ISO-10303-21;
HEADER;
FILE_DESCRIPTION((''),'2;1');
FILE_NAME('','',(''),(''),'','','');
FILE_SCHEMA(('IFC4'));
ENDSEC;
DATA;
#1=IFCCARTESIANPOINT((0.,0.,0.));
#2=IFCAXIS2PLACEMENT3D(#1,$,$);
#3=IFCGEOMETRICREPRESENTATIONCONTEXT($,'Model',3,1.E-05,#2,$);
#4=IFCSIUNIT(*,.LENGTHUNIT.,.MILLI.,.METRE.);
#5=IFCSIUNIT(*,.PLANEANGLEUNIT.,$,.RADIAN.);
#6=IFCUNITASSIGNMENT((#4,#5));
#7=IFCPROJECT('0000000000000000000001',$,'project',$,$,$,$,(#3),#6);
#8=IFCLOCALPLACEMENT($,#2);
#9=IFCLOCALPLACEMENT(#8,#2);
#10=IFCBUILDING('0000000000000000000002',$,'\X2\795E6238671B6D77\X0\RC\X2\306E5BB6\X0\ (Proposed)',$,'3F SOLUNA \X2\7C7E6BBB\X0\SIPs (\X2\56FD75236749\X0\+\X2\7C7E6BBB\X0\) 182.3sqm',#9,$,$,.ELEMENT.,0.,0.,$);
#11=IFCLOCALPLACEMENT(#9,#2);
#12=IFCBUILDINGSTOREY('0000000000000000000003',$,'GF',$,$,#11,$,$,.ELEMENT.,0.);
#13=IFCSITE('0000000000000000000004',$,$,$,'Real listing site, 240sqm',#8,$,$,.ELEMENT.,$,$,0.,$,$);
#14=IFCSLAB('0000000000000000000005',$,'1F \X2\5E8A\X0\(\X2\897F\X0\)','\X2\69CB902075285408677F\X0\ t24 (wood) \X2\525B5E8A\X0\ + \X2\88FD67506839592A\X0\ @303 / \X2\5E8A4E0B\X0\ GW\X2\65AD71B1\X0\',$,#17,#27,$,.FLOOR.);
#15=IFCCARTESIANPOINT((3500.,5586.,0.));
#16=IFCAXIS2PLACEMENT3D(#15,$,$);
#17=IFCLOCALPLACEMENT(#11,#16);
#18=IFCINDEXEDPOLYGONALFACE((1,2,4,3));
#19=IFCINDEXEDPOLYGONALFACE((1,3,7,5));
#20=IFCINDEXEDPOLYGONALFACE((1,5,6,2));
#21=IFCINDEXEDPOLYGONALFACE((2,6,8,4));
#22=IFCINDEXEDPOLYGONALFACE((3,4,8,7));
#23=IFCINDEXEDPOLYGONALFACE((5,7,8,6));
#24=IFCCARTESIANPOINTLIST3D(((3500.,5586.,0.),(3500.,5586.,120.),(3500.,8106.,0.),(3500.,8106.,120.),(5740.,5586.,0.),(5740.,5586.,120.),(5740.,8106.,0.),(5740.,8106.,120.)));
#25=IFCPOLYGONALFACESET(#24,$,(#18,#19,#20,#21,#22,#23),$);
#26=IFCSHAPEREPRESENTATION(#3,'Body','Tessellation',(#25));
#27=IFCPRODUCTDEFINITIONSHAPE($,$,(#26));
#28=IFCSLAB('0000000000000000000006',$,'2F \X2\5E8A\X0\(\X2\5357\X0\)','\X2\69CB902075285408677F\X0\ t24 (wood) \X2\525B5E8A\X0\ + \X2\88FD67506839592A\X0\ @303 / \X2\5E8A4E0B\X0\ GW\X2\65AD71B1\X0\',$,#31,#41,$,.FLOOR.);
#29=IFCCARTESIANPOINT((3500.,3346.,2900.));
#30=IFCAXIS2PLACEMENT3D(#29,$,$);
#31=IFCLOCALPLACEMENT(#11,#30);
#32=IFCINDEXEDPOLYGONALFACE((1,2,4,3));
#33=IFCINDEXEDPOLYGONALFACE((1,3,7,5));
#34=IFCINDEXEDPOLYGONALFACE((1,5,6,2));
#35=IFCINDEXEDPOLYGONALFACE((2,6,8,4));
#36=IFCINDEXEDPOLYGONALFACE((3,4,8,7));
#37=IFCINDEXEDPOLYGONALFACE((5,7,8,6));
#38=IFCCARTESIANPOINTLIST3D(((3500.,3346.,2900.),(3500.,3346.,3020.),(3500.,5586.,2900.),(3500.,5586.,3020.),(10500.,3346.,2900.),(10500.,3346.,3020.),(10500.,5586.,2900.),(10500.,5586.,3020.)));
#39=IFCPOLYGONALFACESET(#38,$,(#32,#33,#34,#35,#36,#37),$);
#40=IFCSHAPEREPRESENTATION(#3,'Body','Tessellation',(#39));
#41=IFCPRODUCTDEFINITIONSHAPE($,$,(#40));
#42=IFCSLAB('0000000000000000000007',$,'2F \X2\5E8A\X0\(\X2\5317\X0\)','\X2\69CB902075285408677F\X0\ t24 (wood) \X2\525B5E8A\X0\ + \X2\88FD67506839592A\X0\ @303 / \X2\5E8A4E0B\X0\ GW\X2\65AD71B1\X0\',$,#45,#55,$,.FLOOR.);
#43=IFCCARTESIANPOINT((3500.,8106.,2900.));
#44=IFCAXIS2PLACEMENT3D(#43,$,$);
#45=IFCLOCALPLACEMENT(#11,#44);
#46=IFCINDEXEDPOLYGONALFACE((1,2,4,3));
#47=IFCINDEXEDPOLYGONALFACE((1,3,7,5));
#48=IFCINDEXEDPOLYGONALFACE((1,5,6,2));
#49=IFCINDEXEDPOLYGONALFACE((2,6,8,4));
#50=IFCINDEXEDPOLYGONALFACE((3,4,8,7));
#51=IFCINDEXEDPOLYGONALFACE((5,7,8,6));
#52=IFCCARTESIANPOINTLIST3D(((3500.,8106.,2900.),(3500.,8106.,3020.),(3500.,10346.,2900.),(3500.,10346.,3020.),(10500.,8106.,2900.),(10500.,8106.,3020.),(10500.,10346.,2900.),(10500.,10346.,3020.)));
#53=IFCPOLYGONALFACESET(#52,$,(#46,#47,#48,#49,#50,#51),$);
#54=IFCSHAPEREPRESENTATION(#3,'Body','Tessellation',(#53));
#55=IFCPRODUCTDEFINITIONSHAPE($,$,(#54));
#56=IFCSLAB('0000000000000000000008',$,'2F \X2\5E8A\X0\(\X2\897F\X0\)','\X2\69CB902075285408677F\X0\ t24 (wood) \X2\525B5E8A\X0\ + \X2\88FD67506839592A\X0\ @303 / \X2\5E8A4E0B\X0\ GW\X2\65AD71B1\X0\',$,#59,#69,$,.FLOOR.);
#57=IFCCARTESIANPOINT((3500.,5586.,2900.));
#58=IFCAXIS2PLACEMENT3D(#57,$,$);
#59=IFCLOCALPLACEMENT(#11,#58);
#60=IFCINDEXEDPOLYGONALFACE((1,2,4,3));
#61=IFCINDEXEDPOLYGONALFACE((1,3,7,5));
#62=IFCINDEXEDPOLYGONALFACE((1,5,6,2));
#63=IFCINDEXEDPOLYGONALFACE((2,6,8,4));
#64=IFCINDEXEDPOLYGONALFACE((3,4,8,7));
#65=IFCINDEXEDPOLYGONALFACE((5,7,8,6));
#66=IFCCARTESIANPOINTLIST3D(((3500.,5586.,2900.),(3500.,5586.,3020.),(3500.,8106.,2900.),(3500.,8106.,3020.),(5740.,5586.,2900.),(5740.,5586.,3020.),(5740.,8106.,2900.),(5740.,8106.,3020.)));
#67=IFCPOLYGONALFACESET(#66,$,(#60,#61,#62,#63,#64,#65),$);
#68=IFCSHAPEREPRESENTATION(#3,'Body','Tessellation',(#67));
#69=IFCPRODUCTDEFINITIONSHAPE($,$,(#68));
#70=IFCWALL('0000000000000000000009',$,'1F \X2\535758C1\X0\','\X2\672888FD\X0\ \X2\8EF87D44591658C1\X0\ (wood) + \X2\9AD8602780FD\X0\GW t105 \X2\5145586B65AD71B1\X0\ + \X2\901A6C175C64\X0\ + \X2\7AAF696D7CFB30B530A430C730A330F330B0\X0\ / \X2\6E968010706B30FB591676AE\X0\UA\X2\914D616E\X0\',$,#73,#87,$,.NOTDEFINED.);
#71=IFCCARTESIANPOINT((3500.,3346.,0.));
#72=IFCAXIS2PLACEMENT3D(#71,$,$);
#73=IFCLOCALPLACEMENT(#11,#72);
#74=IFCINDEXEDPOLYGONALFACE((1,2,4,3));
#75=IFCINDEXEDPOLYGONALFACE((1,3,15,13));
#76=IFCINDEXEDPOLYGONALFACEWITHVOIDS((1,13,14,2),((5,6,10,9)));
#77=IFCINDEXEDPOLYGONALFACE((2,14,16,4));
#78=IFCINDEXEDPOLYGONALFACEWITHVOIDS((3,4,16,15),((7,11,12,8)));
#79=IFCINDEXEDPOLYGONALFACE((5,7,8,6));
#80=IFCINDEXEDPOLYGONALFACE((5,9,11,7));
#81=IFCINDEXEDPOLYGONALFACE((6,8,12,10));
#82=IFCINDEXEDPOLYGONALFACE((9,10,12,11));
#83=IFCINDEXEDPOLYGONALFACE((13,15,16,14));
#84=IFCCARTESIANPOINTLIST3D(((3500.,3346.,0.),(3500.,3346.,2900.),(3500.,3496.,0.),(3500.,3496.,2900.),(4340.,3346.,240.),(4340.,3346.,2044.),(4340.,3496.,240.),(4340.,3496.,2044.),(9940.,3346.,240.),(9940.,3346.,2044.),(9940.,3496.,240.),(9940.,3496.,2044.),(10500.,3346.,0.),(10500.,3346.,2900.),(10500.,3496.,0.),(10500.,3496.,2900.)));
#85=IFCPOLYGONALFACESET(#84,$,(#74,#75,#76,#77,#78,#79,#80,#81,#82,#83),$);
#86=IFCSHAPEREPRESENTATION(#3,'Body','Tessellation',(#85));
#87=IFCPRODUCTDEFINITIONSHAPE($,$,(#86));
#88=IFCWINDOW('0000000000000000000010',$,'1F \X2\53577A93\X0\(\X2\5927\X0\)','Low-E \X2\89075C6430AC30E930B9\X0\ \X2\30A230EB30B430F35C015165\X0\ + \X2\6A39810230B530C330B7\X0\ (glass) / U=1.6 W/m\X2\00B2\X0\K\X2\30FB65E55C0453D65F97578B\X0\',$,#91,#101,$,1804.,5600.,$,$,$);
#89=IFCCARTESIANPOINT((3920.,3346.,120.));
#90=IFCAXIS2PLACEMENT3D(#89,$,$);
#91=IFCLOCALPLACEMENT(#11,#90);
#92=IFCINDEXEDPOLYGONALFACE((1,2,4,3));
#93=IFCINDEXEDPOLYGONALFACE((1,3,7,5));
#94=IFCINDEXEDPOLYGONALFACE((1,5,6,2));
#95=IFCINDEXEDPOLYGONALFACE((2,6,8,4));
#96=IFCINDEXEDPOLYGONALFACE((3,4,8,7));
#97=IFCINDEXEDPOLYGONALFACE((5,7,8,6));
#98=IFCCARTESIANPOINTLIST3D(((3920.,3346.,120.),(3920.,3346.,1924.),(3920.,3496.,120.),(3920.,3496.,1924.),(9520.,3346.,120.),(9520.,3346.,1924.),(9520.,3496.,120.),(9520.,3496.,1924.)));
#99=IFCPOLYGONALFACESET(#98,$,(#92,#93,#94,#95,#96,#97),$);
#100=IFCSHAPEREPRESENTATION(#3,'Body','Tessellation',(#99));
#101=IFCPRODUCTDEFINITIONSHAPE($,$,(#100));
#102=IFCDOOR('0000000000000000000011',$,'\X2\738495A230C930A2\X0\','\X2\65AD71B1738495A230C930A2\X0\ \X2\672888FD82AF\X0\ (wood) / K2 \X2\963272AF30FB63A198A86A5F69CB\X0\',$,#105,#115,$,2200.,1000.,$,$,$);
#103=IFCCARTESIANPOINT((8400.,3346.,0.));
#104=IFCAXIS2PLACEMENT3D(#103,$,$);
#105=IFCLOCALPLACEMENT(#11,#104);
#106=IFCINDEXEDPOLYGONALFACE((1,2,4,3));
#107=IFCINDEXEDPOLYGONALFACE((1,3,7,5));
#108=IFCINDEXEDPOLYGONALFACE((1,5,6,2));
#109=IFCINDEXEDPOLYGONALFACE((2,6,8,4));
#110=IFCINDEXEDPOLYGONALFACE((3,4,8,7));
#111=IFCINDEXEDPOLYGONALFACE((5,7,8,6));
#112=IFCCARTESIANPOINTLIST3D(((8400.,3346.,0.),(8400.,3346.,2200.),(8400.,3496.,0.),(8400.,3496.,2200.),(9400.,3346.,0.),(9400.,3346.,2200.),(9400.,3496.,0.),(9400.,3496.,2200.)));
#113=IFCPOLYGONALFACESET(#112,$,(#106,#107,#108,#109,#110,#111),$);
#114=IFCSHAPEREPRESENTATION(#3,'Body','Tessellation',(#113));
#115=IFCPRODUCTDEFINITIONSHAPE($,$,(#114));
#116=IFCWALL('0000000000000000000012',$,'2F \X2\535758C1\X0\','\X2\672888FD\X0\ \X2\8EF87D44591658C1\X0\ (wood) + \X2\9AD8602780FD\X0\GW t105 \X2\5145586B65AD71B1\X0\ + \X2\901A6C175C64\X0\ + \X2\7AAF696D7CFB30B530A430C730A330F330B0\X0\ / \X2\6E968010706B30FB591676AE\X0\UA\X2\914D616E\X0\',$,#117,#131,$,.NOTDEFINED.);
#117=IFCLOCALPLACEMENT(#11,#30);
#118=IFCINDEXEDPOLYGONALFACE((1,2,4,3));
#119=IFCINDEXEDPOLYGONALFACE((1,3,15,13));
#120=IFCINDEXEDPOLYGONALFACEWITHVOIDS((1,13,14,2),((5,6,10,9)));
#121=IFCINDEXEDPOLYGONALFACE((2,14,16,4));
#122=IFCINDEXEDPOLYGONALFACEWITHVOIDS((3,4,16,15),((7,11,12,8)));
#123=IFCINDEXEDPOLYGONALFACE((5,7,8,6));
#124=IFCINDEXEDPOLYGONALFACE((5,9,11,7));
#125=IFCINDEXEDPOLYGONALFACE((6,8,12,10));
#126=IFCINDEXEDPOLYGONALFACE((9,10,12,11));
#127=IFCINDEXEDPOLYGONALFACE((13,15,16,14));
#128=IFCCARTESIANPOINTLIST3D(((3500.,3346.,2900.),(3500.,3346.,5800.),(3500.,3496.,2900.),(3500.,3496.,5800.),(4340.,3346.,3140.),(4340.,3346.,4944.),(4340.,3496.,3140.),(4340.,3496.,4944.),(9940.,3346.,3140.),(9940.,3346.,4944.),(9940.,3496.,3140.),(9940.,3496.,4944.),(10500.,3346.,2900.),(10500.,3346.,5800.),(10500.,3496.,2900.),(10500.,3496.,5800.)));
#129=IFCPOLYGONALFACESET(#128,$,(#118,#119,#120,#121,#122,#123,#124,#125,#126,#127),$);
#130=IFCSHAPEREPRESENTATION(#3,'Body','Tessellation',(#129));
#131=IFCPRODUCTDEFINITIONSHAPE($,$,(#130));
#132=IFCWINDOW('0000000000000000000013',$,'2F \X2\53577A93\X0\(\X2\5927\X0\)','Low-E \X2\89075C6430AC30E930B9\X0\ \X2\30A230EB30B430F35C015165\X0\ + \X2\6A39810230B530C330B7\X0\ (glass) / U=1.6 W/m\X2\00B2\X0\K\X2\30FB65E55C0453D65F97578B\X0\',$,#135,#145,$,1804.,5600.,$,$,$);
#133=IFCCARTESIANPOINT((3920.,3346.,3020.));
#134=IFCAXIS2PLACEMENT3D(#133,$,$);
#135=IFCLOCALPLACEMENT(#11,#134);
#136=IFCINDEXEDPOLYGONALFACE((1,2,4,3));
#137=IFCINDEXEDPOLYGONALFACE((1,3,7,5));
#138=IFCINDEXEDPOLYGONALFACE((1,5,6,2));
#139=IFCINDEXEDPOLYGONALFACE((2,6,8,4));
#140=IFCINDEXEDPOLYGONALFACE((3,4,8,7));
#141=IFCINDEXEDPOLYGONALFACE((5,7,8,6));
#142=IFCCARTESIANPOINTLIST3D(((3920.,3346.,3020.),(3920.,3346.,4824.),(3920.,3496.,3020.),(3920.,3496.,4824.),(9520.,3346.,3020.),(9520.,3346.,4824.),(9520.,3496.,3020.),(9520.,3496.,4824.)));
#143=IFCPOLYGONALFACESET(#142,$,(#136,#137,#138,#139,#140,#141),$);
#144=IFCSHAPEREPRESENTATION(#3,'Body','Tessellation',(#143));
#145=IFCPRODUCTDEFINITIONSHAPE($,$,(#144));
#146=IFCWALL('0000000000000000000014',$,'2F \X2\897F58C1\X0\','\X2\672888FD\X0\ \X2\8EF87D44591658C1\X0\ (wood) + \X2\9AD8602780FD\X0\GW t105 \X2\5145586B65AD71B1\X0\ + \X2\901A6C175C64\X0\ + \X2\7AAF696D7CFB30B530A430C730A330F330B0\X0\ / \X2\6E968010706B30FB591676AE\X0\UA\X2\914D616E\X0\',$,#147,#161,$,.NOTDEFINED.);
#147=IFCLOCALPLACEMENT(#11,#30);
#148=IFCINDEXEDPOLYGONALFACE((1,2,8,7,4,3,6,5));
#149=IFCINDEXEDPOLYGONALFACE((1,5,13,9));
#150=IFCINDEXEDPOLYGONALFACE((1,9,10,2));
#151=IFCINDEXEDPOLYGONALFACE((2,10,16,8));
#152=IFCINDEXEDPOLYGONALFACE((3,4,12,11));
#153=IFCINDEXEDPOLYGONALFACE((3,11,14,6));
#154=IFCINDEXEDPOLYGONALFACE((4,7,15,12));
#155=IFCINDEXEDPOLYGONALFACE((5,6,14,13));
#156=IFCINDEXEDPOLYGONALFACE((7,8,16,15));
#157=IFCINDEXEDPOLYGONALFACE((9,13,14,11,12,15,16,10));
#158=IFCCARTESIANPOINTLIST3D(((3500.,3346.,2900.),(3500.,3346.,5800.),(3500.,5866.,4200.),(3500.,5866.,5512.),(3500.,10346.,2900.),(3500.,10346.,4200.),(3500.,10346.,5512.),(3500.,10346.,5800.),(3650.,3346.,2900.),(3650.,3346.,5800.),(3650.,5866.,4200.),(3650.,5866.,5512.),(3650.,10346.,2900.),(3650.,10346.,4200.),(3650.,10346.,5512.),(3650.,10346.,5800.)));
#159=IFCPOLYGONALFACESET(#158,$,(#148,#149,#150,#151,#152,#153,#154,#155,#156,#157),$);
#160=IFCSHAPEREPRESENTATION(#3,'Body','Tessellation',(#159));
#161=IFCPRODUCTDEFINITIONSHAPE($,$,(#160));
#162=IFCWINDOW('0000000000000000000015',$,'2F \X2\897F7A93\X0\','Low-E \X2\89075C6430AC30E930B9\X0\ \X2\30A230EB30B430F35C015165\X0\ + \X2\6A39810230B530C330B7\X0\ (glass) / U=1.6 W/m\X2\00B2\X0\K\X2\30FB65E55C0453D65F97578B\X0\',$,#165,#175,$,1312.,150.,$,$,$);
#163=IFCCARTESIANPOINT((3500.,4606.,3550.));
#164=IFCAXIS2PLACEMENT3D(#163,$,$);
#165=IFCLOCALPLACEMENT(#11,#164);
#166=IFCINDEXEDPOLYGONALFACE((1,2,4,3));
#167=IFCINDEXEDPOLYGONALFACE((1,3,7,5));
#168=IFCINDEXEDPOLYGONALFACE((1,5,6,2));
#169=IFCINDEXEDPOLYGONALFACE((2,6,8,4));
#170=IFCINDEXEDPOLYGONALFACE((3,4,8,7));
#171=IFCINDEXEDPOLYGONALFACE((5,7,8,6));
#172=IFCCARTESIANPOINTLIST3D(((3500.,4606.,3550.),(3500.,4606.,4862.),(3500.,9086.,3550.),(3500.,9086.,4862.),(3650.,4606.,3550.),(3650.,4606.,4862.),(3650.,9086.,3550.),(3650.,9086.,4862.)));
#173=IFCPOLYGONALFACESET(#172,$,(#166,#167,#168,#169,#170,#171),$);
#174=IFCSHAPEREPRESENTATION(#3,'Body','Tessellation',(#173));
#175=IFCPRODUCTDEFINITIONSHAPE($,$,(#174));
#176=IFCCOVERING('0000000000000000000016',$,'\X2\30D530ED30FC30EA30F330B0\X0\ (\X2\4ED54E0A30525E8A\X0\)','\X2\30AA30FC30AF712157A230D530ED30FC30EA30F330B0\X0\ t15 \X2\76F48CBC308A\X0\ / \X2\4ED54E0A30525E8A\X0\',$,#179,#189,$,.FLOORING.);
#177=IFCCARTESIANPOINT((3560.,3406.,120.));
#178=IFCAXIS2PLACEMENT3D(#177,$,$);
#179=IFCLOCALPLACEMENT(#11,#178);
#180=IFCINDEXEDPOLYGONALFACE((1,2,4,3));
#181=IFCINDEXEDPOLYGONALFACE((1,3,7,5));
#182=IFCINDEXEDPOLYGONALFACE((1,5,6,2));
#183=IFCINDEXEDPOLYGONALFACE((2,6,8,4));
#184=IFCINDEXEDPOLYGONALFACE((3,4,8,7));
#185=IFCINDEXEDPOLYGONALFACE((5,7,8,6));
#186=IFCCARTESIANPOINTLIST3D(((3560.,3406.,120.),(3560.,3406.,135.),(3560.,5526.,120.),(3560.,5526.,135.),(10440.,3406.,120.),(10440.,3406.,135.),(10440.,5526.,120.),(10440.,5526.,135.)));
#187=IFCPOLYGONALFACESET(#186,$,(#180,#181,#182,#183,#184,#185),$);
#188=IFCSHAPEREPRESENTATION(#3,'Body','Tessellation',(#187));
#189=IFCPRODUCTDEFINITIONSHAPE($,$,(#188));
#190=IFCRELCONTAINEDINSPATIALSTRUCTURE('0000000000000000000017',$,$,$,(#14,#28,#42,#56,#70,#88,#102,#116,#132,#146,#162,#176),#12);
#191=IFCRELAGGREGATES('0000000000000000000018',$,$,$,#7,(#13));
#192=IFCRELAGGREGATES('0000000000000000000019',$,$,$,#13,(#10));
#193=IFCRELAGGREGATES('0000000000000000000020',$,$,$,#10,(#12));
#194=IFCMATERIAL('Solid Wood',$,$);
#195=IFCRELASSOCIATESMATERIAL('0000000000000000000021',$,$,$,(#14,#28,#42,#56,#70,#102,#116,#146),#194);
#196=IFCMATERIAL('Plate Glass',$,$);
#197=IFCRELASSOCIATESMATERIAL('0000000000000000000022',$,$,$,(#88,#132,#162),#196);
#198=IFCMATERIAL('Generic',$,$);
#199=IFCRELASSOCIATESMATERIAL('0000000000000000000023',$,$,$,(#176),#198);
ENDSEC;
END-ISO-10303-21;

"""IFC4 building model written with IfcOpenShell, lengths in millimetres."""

from ifc_helpers import new_model, si_unit, frame, frame_2d, origin, place, context, project, spatial, rectangle, extrude, material, element, fill, save


model = new_model("IFC4")

# Units and contexts
model_context = context("Model", 3, precision=1e-05, world=origin())
ifc_project = project(units=[si_unit("LENGTHUNIT", "METRE", prefix="MILLI"), si_unit("PLANEANGLEUNIT", "RADIAN")], contexts=[model_context])

# Site, building, storey
site_placement = place(None, origin())
site = spatial("IfcSite", under=ifc_project, at=site_placement, ObjectType="Real listing site, 240sqm", CompositionType="ELEMENT", RefElevation=0.0)
building_placement = place(site_placement, origin())
building = spatial("IfcBuilding", under=site, at=building_placement, Name="神戸望海RCの家 (Proposed)", ObjectType="3F SOLUNA 籾殻SIPs (国産杉+籾殻) 182.3sqm", CompositionType="ELEMENT", ElevationOfRefHeight=0.0, ElevationOfTerrain=0.0)
storey_placement = place(building_placement, origin())
storey = spatial("IfcBuildingStorey", under=building, at=storey_placement, Name="GF", CompositionType="ELEMENT", Elevation=0.0)

# Slabs
ifc_material_1 = material(Name="Solid Wood")
slab_1_placement = place(storey_placement, frame((3500.0, 5586.0, 0.0)))
element("IfcSlab", 1, at=slab_1_placement, inside=storey, material=ifc_material_1, Name="1F 床(西)", Description="構造用合板 t24 (wood) 剛床 + 製材根太 @303 / 床下 GW断熱", PredefinedType="FLOOR", context=model_context, shape_type="SweptSolid", body=[
    extrude(rectangle(XDim=2240.0, YDim=2520.0, at=frame_2d((1120.0, 1260.0))), frame((3500.0, 5586.0, 0.0)), (0.0, 0.0, 1.0), 120.0),
])
slab_2_placement = place(storey_placement, frame((3500.0, 3346.0, 2900.0)))
element("IfcSlab", 2, at=slab_2_placement, inside=storey, material=ifc_material_1, Name="2F 床(南)", Description="構造用合板 t24 (wood) 剛床 + 製材根太 @303 / 床下 GW断熱", PredefinedType="FLOOR", context=model_context, shape_type="SweptSolid", body=[
    extrude(rectangle(XDim=7000.0, YDim=2240.0, at=frame_2d((3500.0, 1120.0))), frame((3500.0, 3346.0, 2900.0)), (0.0, 0.0, 1.0), 120.0),
])
slab_3_placement = place(storey_placement, frame((3500.0, 8106.0, 2900.0)))
element("IfcSlab", 3, at=slab_3_placement, inside=storey, material=ifc_material_1, Name="2F 床(北)", Description="構造用合板 t24 (wood) 剛床 + 製材根太 @303 / 床下 GW断熱", PredefinedType="FLOOR", context=model_context, shape_type="SweptSolid", body=[
    extrude(rectangle(XDim=7000.0, YDim=2240.0, at=frame_2d((3500.0, 1120.0))), frame((3500.0, 8106.0, 2900.0)), (0.0, 0.0, 1.0), 120.0),
])
slab_4_placement = place(storey_placement, frame((3500.0, 5586.0, 2900.0)))
element("IfcSlab", 4, at=slab_4_placement, inside=storey, material=ifc_material_1, Name="2F 床(西)", Description="構造用合板 t24 (wood) 剛床 + 製材根太 @303 / 床下 GW断熱", PredefinedType="FLOOR", context=model_context, shape_type="SweptSolid", body=[
    extrude(rectangle(XDim=2240.0, YDim=2520.0, at=frame_2d((1120.0, 1260.0))), frame((3500.0, 5586.0, 2900.0)), (0.0, 0.0, 1.0), 120.0),
])

# Wall, openings, window, door
wall_1_placement = place(storey_placement, frame((3500.0, 3346.0, 0.0)))
wall_1 = element("IfcWall", 5, at=wall_1_placement, inside=storey, material=ifc_material_1, Name="1F 南壁", Description="木製 軸組外壁 (wood) + 高性能GW t105 充填断熱 + 通気層 + 窯業系サイディング / 準耐火・外皮UA配慮", PredefinedType="NOTDEFINED", context=model_context, shape_type="SweptSolid", body=[
    extrude(rectangle(XDim=7000.0, YDim=150.0, at=frame_2d((3500.0, 75.0))), frame((3500.0, 3346.0, 0.0)), (0.0, 0.0, 1.0), 2900.0),
])
opening_1_placement = place(storey_placement, frame((3920.0, 3346.0, 120.0)))
opening_1 = element("IfcOpeningElement", 6, at=opening_1_placement, cuts=wall_1, PredefinedType="NOTDEFINED", context=model_context, shape_type="SweptSolid", body=[
    extrude(rectangle(XDim=5600.0, YDim=150.0, at=frame_2d((2800.0, 75.0))), frame((3920.0, 3346.0, 120.0)), (0.0, 0.0, 1.0), 1804.0),
])
opening_2_placement = place(storey_placement, frame((8400.0, 3346.0, 0.0)))
opening_2 = element("IfcOpeningElement", 7, at=opening_2_placement, cuts=wall_1, PredefinedType="NOTDEFINED", context=model_context, shape_type="SweptSolid", body=[
    extrude(rectangle(XDim=1000.0, YDim=150.0, at=frame_2d((500.0, 75.0))), frame((8400.0, 3346.0, 0.0)), (0.0, 0.0, 1.0), 2200.0),
])
ifc_material_2 = material(Name="Plate Glass")
window_1_placement = place(storey_placement, frame((3920.0, 3346.0, 120.0)))
window_1 = element("IfcWindow", 8, at=window_1_placement, inside=storey, material=ifc_material_2, Name="1F 南窓(大)", Description="Low-E 複層ガラス アルゴン封入 + 樹脂サッシ (glass) / U=1.6 W/m²K・日射取得型", OverallHeight=1804.0, OverallWidth=5600.0, context=model_context, shape_type="SweptSolid", body=[
    extrude(rectangle(XDim=5600.0, YDim=150.0, at=frame_2d((2800.0, 75.0))), frame((3920.0, 3346.0, 120.0)), (0.0, 0.0, 1.0), 1804.0),
])
fill(opening_1, window_1)
door_placement = place(storey_placement, frame((8400.0, 3346.0, 0.0)))
door = element("IfcDoor", 9, at=door_placement, inside=storey, material=ifc_material_1, Name="玄関ドア", Description="断熱玄関ドア 木製芯 (wood) / K2 防犯・採風機構", OverallHeight=2200.0, OverallWidth=1000.0, context=model_context, shape_type="SweptSolid", body=[
    extrude(rectangle(XDim=1000.0, YDim=150.0, at=frame_2d((500.0, 75.0))), frame((8400.0, 3346.0, 0.0)), (0.0, 0.0, 1.0), 2200.0),
])
fill(opening_2, door)

# Wall, opening, window
wall_2_placement = place(storey_placement, frame((3500.0, 3346.0, 2900.0)))
wall_2 = element("IfcWall", 10, at=wall_2_placement, inside=storey, material=ifc_material_1, Name="2F 南壁", Description="木製 軸組外壁 (wood) + 高性能GW t105 充填断熱 + 通気層 + 窯業系サイディング / 準耐火・外皮UA配慮", PredefinedType="NOTDEFINED", context=model_context, shape_type="SweptSolid", body=[
    extrude(rectangle(XDim=7000.0, YDim=150.0, at=frame_2d((3500.0, 75.0))), frame((3500.0, 3346.0, 2900.0)), (0.0, 0.0, 1.0), 2900.0),
])
opening_3_placement = place(storey_placement, frame((3920.0, 3346.0, 3020.0)))
opening_3 = element("IfcOpeningElement", 11, at=opening_3_placement, cuts=wall_2, PredefinedType="NOTDEFINED", context=model_context, shape_type="SweptSolid", body=[
    extrude(rectangle(XDim=5600.0, YDim=150.0, at=frame_2d((2800.0, 75.0))), frame((3920.0, 3346.0, 3020.0)), (0.0, 0.0, 1.0), 1804.0),
])
window_2_placement = place(storey_placement, frame((3920.0, 3346.0, 3020.0)))
window_2 = element("IfcWindow", 12, at=window_2_placement, inside=storey, material=ifc_material_2, Name="2F 南窓(大)", Description="Low-E 複層ガラス アルゴン封入 + 樹脂サッシ (glass) / U=1.6 W/m²K・日射取得型", OverallHeight=1804.0, OverallWidth=5600.0, context=model_context, shape_type="SweptSolid", body=[
    extrude(rectangle(XDim=5600.0, YDim=150.0, at=frame_2d((2800.0, 75.0))), frame((3920.0, 3346.0, 3020.0)), (0.0, 0.0, 1.0), 1804.0),
])
fill(opening_3, window_2)

# Wall, opening, window
wall_3_placement = place(storey_placement, frame((3500.0, 3346.0, 2900.0)))
wall_3 = element("IfcWall", 13, at=wall_3_placement, inside=storey, material=ifc_material_1, Name="2F 西壁", Description="木製 軸組外壁 (wood) + 高性能GW t105 充填断熱 + 通気層 + 窯業系サイディング / 準耐火・外皮UA配慮", PredefinedType="NOTDEFINED", context=model_context, shape_type="SweptSolid", body=[
    extrude(rectangle(XDim=150.0, YDim=7000.0, at=frame_2d((75.0, 3500.0))), frame((3500.0, 3346.0, 2900.0)), (0.0, 0.0, 1.0), 2900.0),
])
opening_4_placement = place(storey_placement, frame((3500.0, 4606.0, 3550.0)))
opening_4 = element("IfcOpeningElement", 14, at=opening_4_placement, cuts=wall_3, PredefinedType="NOTDEFINED", context=model_context, shape_type="SweptSolid", body=[
    extrude(rectangle(XDim=150.0, YDim=4480.0, at=frame_2d((75.0, 2240.0))), frame((3500.0, 4606.0, 3550.0)), (0.0, 0.0, 1.0), 1312.0),
])
window_3_placement = place(storey_placement, frame((3500.0, 4606.0, 3550.0)))
window_3 = element("IfcWindow", 15, at=window_3_placement, inside=storey, material=ifc_material_2, Name="2F 西窓", Description="Low-E 複層ガラス アルゴン封入 + 樹脂サッシ (glass) / U=1.6 W/m²K・日射取得型", OverallHeight=1312.0, OverallWidth=150.0, context=model_context, shape_type="SweptSolid", body=[
    extrude(rectangle(XDim=150.0, YDim=4480.0, at=frame_2d((75.0, 2240.0))), frame((3500.0, 4606.0, 3550.0)), (0.0, 0.0, 1.0), 1312.0),
])
fill(opening_4, window_3)

# Covering
ifc_material_3 = material(Name="Generic")
covering_1_placement = place(storey_placement, frame((3560.0, 3406.0, 120.0)))
element("IfcCovering", 16, at=covering_1_placement, inside=storey, material=ifc_material_3, Name="フローリング (仕上げ床)", Description="オーク無垢フローリング t15 直貼り / 仕上げ床", PredefinedType="FLOORING", context=model_context, shape_type="SweptSolid", body=[
    extrude(rectangle(XDim=6880.0, YDim=2120.0, at=frame_2d((3440.0, 1060.0))), frame((3560.0, 3406.0, 120.0)), (0.0, 0.0, 1.0), 15.0),
])

save(model, "model.ifc")
